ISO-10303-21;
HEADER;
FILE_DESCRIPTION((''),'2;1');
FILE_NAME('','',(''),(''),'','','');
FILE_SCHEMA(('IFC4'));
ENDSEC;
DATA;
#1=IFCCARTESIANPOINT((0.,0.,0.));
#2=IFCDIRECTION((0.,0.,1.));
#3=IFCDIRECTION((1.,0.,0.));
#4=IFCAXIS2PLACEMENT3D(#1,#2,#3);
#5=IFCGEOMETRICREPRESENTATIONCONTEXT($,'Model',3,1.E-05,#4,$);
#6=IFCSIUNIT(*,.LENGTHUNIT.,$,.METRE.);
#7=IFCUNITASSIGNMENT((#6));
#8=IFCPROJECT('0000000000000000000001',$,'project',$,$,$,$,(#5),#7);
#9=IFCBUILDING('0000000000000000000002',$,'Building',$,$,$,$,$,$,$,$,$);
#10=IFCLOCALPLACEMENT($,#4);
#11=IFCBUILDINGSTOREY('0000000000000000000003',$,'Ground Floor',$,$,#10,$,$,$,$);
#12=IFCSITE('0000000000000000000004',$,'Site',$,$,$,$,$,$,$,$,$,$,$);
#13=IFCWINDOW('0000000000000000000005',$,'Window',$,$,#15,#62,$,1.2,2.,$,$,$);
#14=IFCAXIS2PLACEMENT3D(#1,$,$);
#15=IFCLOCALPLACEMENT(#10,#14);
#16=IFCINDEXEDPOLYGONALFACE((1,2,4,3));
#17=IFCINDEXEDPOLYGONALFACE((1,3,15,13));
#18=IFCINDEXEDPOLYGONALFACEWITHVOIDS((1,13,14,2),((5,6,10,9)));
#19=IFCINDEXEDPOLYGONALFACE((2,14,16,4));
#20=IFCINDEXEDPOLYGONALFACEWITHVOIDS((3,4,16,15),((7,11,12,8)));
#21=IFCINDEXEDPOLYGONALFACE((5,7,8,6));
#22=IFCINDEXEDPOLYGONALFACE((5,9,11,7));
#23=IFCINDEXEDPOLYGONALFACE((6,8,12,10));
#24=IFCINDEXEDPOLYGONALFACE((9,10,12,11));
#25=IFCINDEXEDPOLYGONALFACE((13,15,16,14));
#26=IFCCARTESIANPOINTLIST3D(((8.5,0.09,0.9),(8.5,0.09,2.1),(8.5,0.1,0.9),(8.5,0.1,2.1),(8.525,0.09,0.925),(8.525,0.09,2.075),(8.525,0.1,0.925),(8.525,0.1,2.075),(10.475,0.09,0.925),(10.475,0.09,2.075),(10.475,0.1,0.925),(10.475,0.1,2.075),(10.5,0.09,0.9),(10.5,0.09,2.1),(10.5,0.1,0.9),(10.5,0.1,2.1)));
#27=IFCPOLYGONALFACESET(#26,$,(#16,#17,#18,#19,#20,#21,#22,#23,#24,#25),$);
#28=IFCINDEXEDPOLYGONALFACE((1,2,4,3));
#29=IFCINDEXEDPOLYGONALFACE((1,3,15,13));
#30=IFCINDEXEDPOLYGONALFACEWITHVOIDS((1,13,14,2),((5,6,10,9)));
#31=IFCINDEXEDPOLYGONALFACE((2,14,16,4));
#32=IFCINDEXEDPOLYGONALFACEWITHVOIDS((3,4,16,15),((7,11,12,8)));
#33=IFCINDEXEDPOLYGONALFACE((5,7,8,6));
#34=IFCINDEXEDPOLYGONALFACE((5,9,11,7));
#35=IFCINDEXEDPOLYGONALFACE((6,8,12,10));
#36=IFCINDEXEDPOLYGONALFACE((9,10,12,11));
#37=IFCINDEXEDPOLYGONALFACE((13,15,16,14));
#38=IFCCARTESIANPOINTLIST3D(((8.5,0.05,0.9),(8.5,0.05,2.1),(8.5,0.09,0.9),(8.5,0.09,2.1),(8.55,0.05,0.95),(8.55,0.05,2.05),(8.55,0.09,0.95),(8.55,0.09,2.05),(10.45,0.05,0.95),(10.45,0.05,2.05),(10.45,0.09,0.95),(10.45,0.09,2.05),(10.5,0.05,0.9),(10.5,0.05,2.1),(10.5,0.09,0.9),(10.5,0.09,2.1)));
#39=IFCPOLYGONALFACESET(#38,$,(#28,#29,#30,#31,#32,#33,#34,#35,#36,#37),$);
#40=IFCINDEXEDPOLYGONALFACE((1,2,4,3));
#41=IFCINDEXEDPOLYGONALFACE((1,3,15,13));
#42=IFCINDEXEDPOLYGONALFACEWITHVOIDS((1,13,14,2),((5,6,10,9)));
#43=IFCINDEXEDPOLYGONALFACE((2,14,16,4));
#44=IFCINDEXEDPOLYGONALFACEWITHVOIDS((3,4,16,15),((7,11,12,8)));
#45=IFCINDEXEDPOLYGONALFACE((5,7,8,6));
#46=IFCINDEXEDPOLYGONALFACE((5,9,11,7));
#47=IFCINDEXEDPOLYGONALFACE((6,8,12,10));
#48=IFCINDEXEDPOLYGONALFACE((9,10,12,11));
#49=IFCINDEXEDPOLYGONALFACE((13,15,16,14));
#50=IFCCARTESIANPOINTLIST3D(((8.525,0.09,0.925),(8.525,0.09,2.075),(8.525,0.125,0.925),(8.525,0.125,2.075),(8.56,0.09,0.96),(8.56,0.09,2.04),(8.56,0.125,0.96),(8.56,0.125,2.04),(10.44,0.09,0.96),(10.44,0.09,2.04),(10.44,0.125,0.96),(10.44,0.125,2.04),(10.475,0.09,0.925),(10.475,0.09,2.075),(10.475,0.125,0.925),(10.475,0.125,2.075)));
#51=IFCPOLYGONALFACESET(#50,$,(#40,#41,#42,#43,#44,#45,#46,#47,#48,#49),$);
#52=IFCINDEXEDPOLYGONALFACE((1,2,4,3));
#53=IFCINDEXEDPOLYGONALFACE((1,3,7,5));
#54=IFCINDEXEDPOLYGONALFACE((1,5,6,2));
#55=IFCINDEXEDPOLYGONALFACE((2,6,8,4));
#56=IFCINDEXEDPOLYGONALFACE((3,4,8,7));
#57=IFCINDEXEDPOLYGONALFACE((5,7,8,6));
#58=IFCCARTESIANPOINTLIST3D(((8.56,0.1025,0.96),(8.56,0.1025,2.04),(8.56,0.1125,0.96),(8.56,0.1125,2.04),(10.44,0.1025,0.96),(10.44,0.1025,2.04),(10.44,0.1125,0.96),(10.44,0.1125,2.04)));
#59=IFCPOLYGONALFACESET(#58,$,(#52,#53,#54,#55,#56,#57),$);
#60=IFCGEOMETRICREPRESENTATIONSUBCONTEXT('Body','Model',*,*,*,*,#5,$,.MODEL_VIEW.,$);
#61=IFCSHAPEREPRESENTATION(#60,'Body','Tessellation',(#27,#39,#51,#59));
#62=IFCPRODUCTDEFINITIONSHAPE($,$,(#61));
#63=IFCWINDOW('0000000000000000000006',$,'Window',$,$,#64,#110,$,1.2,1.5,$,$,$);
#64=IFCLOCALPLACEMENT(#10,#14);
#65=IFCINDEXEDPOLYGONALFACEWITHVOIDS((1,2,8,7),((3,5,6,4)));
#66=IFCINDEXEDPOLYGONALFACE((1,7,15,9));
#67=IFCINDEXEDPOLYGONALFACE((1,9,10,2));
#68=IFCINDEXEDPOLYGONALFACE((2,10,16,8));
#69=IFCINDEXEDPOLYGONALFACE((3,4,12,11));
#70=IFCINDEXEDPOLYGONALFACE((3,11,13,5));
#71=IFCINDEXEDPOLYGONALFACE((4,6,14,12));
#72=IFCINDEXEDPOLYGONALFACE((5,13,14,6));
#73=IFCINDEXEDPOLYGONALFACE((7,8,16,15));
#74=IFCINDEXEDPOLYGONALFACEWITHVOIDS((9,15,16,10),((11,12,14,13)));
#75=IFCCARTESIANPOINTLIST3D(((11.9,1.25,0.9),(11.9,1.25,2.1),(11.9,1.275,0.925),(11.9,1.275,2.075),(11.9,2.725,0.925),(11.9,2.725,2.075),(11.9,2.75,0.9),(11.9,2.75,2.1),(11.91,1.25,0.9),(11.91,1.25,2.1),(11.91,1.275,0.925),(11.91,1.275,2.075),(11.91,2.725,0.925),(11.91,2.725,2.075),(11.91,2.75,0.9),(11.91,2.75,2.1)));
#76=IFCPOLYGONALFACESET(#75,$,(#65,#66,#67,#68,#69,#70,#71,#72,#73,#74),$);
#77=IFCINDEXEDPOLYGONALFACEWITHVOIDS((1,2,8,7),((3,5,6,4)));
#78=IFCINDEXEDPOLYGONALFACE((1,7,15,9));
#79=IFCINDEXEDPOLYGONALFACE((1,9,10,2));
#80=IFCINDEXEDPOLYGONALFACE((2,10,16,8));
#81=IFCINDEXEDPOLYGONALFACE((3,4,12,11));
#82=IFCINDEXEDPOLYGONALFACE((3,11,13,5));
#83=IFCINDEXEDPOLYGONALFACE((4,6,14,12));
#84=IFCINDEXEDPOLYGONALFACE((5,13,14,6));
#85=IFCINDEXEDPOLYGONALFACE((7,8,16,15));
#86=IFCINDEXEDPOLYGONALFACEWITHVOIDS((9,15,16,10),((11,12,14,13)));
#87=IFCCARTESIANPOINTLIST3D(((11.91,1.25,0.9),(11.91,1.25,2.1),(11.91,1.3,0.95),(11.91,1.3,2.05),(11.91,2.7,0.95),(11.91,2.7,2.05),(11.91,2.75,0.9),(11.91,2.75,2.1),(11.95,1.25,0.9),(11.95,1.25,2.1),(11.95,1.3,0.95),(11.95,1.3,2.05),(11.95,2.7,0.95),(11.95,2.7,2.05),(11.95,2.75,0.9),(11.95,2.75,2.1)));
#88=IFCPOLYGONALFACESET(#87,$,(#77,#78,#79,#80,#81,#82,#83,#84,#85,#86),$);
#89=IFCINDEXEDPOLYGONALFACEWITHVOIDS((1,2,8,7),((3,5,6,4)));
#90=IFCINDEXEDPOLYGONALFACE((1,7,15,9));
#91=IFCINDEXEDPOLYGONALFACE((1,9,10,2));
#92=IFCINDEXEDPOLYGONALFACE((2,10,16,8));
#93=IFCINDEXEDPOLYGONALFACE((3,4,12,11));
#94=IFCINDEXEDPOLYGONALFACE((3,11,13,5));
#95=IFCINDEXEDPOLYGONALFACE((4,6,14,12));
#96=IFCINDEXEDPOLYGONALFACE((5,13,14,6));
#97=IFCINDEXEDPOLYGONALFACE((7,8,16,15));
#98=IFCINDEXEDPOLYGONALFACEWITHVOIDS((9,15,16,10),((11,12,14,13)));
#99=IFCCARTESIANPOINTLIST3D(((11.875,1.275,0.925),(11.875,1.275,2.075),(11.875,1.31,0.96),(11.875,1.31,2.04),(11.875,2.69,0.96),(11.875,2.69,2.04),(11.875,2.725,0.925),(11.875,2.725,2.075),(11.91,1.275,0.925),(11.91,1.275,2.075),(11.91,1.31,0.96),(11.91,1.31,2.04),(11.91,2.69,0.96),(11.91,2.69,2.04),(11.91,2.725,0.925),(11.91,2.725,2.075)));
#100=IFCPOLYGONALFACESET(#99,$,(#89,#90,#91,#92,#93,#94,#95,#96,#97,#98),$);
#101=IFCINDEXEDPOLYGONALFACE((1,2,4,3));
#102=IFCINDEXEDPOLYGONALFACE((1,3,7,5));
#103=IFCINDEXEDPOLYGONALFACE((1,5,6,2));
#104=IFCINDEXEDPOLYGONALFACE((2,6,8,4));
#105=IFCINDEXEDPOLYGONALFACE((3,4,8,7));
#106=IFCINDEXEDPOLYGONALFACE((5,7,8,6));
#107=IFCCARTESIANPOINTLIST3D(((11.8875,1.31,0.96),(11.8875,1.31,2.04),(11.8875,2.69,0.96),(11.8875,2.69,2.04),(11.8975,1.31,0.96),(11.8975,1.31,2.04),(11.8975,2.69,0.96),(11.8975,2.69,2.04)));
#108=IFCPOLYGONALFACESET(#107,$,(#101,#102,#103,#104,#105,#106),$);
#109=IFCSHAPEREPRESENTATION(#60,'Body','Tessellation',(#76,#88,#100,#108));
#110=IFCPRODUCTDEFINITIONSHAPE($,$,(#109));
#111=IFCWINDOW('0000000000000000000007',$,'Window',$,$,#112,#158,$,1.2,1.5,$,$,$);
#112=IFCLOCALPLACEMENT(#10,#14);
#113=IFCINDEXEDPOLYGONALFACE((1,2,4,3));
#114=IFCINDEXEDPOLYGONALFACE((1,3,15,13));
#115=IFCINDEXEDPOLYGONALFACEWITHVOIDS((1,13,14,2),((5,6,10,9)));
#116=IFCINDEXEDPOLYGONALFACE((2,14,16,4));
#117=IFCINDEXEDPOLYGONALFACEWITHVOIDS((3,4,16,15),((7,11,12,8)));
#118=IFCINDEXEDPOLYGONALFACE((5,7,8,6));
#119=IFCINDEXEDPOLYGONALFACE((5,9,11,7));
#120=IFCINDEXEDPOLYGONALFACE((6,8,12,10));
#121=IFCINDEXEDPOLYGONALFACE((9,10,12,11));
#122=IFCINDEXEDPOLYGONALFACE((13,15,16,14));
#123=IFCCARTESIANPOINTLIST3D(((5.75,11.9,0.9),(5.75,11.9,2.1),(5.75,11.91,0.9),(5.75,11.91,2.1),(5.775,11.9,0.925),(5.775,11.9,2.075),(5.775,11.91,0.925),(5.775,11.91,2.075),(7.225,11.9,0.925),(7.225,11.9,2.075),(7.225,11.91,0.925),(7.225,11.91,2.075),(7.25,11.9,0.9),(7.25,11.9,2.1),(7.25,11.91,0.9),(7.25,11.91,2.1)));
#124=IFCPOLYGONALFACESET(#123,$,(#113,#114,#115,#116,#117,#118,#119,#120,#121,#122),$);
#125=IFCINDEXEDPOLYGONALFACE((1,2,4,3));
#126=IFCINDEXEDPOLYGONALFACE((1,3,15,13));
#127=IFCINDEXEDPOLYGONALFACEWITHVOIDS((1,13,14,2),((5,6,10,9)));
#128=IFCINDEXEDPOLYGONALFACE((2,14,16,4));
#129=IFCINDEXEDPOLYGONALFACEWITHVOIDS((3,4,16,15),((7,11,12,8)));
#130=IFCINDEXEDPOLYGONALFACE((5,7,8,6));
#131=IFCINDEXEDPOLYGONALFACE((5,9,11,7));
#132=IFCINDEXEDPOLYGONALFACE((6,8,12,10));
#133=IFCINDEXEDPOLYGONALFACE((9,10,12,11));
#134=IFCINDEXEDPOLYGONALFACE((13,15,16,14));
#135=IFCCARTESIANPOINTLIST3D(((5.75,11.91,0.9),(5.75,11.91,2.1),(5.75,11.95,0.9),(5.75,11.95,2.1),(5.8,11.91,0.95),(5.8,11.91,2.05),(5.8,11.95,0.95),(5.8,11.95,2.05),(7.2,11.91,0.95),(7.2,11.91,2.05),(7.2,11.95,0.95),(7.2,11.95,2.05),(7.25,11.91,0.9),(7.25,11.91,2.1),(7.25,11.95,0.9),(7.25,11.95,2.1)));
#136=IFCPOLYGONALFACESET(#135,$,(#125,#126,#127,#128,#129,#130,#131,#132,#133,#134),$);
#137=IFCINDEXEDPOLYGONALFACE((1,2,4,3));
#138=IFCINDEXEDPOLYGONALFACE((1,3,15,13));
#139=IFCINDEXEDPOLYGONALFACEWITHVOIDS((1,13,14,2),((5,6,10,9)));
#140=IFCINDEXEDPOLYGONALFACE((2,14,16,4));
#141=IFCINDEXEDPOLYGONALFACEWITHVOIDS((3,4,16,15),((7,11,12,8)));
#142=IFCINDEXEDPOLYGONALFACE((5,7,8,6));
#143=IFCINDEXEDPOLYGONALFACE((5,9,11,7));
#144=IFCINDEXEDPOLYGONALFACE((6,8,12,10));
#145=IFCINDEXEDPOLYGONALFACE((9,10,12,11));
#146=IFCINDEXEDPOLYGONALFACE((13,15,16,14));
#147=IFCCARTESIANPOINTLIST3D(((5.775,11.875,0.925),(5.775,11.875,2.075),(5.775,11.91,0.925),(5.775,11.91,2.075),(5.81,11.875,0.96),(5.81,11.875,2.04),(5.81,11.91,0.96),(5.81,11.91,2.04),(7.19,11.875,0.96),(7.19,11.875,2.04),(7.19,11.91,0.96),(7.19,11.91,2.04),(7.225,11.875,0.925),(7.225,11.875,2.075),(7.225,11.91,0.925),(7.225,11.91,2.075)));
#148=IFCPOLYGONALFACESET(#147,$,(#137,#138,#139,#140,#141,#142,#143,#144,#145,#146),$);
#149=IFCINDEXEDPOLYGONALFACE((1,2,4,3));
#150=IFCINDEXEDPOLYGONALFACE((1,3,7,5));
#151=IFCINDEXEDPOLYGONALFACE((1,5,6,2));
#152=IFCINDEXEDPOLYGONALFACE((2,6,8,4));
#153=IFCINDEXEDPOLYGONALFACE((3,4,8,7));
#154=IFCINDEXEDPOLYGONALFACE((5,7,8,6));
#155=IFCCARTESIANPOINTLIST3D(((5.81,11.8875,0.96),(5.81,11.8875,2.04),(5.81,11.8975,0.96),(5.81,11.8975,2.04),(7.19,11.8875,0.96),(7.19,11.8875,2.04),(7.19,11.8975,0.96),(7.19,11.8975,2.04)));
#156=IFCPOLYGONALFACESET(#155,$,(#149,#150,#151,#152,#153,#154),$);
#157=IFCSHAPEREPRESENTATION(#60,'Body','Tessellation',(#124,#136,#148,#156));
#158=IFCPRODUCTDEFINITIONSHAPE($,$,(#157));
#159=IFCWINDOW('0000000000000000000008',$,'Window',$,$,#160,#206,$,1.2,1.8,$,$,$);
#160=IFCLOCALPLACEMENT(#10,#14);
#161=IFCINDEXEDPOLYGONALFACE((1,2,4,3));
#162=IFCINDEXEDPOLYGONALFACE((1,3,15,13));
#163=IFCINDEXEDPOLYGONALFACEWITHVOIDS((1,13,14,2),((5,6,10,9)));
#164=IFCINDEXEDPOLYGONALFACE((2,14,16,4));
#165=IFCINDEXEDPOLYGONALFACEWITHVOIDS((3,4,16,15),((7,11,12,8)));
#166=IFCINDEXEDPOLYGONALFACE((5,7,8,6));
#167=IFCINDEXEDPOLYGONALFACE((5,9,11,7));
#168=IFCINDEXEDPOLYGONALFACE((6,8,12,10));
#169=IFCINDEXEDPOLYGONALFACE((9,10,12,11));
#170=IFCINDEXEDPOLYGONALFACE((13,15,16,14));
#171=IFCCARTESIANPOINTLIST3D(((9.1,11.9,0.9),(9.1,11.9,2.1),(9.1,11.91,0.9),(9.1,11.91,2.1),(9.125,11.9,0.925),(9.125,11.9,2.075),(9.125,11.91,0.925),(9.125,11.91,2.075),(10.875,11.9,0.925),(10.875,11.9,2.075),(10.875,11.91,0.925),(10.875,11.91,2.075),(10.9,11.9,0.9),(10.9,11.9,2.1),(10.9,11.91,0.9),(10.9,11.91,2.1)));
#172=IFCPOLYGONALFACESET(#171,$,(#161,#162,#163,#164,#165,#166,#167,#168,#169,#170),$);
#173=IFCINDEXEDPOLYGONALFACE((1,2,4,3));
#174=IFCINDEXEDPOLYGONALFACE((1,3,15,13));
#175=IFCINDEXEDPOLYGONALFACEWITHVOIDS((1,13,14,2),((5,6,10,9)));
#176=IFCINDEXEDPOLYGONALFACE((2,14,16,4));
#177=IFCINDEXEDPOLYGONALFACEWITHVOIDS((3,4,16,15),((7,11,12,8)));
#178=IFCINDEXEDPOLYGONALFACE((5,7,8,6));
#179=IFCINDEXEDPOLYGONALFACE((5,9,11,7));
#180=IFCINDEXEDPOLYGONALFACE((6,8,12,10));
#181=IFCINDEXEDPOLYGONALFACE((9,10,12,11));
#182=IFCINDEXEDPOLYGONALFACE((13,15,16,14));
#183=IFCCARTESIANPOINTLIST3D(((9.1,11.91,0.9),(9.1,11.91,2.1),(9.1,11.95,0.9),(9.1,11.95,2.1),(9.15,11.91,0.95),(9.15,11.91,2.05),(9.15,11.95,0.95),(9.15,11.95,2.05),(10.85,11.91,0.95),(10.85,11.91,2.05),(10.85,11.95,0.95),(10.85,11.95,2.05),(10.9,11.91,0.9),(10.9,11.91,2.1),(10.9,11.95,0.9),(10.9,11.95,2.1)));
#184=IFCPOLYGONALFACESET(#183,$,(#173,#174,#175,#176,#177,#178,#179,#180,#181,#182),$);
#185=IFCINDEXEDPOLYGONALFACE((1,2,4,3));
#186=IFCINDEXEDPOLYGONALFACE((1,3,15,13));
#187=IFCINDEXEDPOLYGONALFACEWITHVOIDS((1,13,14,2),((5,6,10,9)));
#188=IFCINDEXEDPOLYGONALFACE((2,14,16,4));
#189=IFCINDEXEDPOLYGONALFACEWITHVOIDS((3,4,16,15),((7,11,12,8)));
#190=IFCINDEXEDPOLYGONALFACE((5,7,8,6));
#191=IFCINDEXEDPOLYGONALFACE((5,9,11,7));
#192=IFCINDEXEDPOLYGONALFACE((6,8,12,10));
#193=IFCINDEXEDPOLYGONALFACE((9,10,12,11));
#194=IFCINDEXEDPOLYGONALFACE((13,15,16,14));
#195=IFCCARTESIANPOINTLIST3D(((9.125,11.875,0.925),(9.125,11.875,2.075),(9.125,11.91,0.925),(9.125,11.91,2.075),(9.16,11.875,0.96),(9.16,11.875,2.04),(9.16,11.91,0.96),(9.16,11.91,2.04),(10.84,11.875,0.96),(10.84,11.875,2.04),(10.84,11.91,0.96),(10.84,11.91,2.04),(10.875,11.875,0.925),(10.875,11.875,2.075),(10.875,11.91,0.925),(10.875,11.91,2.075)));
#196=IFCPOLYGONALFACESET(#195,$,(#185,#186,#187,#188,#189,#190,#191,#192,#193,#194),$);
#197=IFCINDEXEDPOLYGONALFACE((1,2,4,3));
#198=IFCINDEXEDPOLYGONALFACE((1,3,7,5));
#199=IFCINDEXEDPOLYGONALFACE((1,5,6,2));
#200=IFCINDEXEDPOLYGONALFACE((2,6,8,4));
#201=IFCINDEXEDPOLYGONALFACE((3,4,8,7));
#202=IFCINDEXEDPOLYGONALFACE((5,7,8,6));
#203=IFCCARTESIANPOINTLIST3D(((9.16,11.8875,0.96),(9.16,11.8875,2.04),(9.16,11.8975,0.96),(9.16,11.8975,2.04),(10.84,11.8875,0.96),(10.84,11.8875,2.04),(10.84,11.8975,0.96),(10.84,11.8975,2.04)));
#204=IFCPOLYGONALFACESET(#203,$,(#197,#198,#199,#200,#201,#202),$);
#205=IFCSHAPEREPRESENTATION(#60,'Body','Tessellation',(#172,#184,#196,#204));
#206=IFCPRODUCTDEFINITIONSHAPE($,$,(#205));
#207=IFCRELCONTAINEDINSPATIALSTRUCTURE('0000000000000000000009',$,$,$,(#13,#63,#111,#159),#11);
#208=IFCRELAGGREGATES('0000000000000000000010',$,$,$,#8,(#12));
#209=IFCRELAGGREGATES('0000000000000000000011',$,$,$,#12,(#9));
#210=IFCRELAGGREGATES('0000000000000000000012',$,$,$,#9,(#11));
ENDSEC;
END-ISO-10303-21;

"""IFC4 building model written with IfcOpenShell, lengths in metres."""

from ifc_helpers import new_model, si_unit, frame, origin_with_axes, place, context, subcontext, project, spatial, line, indexed_curve, outline, extrude, element, save


model = new_model("IFC4")

# Units and contexts
model_context = context("Model", 3, precision=1e-05, world=origin_with_axes())
body_context = subcontext(model_context, "Body", "Model", "MODEL_VIEW")
ifc_project = project(units=[si_unit("LENGTHUNIT", "METRE")], contexts=[model_context])

# Site, building, storey
site = spatial("IfcSite", under=ifc_project, Name="Site")
building = spatial("IfcBuilding", under=site, Name="Building")
storey_placement = place(None, origin_with_axes())
storey = spatial("IfcBuildingStorey", under=building, at=storey_placement, Name="Ground Floor")

# Windows
window_1_placement = place(storey_placement, frame((8.5, 0.0, 0.9), z_axis=(0.0, 0.0, 1.0), x_axis=(1.0, 0.0, 0.0)))
element("IfcWindow", 1, at=window_1_placement, inside=storey, Name="Window", OverallHeight=1.2, OverallWidth=2.0, context=body_context, shape_type="SweptSolid", body=[
    extrude(outline(indexed_curve([(0.0, 0.0), (2.0, 0.0), (2.0, 1.2), (0.0, 1.2)], segments=[line(1, 2, 3, 4, 1)]), holes=[indexed_curve([(0.025, 0.025), (1.975, 0.025), (1.975, 1.175), (0.025, 1.175)], segments=[line(1, 2, 3, 4, 1)])]), frame((0.0, 0.09, 0.0), z_axis=(0.0, -1.0, 0.0), x_axis=(1.0, 0.0, 0.0)), (0.0, 0.0, -1.0), 0.01),
    extrude(outline(indexed_curve([(0.0, 0.0), (2.0, 0.0), (2.0, 1.2), (0.0, 1.2)], segments=[line(1, 2, 3, 4, 1)]), holes=[indexed_curve([(0.05, 0.05), (1.95, 0.05), (1.95, 1.15), (0.05, 1.15)], segments=[line(1, 2, 3, 4, 1)])]), frame((0.0, 0.05, 0.0), z_axis=(0.0, -1.0, 0.0), x_axis=(1.0, 0.0, 0.0)), (0.0, 0.0, -1.0), 0.04),
    extrude(outline(indexed_curve([(0.0, 0.0), (1.95, 0.0), (1.95, 1.15), (0.0, 1.15)], segments=[line(1, 2, 3, 4, 1)]), holes=[indexed_curve([(0.035, 0.035), (1.915, 0.035), (1.915, 1.115), (0.035, 1.115)], segments=[line(1, 2, 3, 4, 1)])]), frame((0.025, 0.09, 0.025), z_axis=(0.0, -1.0, 0.0), x_axis=(1.0, 0.0, 0.0)), (0.0, 0.0, -1.0), 0.035),
    extrude(outline(indexed_curve([(0.035, 0.035), (1.915, 0.035), (1.915, 1.115), (0.035, 1.115)], segments=[line(1, 2, 3, 4, 1)])), frame((0.025, 0.1025, 0.025), z_axis=(0.0, -1.0, 0.0), x_axis=(1.0, 0.0, 0.0)), (0.0, 0.0, -1.0), 0.01),
])
for number, where, z_axis, x_axis, name in (
    (2, (12.0, 1.25, 0.9), (0.0, 0.0, 1.0), (0.0, 1.0, 0.0), "Window"),
    (3, (7.25, 12.0, 0.9), (0.0, 0.0, 1.0), (-1.0, 0.0, 0.0), "Window"),
):
    element("IfcWindow", number, at=place(storey_placement, frame(where, z_axis=z_axis, x_axis=x_axis)), inside=storey, Name=name, OverallHeight=1.2, OverallWidth=1.5, context=body_context, shape_type="SweptSolid", body=[
        extrude(outline(indexed_curve([(0.0, 0.0), (1.5, 0.0), (1.5, 1.2), (0.0, 1.2)], segments=[line(1, 2, 3, 4, 1)]), holes=[indexed_curve([(0.025, 0.025), (1.475, 0.025), (1.475, 1.175), (0.025, 1.175)], segments=[line(1, 2, 3, 4, 1)])]), frame((0.0, 0.09, 0.0), z_axis=(0.0, -1.0, 0.0), x_axis=(1.0, 0.0, 0.0)), (0.0, 0.0, -1.0), 0.01),
        extrude(outline(indexed_curve([(0.0, 0.0), (1.5, 0.0), (1.5, 1.2), (0.0, 1.2)], segments=[line(1, 2, 3, 4, 1)]), holes=[indexed_curve([(0.05, 0.05), (1.45, 0.05), (1.45, 1.15), (0.05, 1.15)], segments=[line(1, 2, 3, 4, 1)])]), frame((0.0, 0.05, 0.0), z_axis=(0.0, -1.0, 0.0), x_axis=(1.0, 0.0, 0.0)), (0.0, 0.0, -1.0), 0.04),
        extrude(outline(indexed_curve([(0.0, 0.0), (1.45, 0.0), (1.45, 1.15), (0.0, 1.15)], segments=[line(1, 2, 3, 4, 1)]), holes=[indexed_curve([(0.035, 0.035), (1.415, 0.035), (1.415, 1.115), (0.035, 1.115)], segments=[line(1, 2, 3, 4, 1)])]), frame((0.025, 0.09, 0.025), z_axis=(0.0, -1.0, 0.0), x_axis=(1.0, 0.0, 0.0)), (0.0, 0.0, -1.0), 0.035),
        extrude(outline(indexed_curve([(0.035, 0.035), (1.415, 0.035), (1.415, 1.115), (0.035, 1.115)], segments=[line(1, 2, 3, 4, 1)])), frame((0.025, 0.1025, 0.025), z_axis=(0.0, -1.0, 0.0), x_axis=(1.0, 0.0, 0.0)), (0.0, 0.0, -1.0), 0.01),
    ])
window_2_placement = place(storey_placement, frame((10.9, 12.0, 0.9), z_axis=(0.0, 0.0, 1.0), x_axis=(-1.0, 0.0, 0.0)))
element("IfcWindow", 4, at=window_2_placement, inside=storey, Name="Window", OverallHeight=1.2, OverallWidth=1.8, context=body_context, shape_type="SweptSolid", body=[
    extrude(outline(indexed_curve([(0.0, 0.0), (1.8, 0.0), (1.8, 1.2), (0.0, 1.2)], segments=[line(1, 2, 3, 4, 1)]), holes=[indexed_curve([(0.025, 0.025), (1.775, 0.025), (1.775, 1.175), (0.025, 1.175)], segments=[line(1, 2, 3, 4, 1)])]), frame((0.0, 0.09, 0.0), z_axis=(0.0, -1.0, 0.0), x_axis=(1.0, 0.0, 0.0)), (0.0, 0.0, -1.0), 0.01),
    extrude(outline(indexed_curve([(0.0, 0.0), (1.8, 0.0), (1.8, 1.2), (0.0, 1.2)], segments=[line(1, 2, 3, 4, 1)]), holes=[indexed_curve([(0.05, 0.05), (1.75, 0.05), (1.75, 1.15), (0.05, 1.15)], segments=[line(1, 2, 3, 4, 1)])]), frame((0.0, 0.05, 0.0), z_axis=(0.0, -1.0, 0.0), x_axis=(1.0, 0.0, 0.0)), (0.0, 0.0, -1.0), 0.04),
    extrude(outline(indexed_curve([(0.0, 0.0), (1.75, 0.0), (1.75, 1.15), (0.0, 1.15)], segments=[line(1, 2, 3, 4, 1)]), holes=[indexed_curve([(0.035, 0.035), (1.715, 0.035), (1.715, 1.115), (0.035, 1.115)], segments=[line(1, 2, 3, 4, 1)])]), frame((0.025, 0.09, 0.025), z_axis=(0.0, -1.0, 0.0), x_axis=(1.0, 0.0, 0.0)), (0.0, 0.0, -1.0), 0.035),
    extrude(outline(indexed_curve([(0.035, 0.035), (1.715, 0.035), (1.715, 1.115), (0.035, 1.115)], segments=[line(1, 2, 3, 4, 1)])), frame((0.025, 0.1025, 0.025), z_axis=(0.0, -1.0, 0.0), x_axis=(1.0, 0.0, 0.0)), (0.0, 0.0, -1.0), 0.01),
])

save(model, "model.ifc")
